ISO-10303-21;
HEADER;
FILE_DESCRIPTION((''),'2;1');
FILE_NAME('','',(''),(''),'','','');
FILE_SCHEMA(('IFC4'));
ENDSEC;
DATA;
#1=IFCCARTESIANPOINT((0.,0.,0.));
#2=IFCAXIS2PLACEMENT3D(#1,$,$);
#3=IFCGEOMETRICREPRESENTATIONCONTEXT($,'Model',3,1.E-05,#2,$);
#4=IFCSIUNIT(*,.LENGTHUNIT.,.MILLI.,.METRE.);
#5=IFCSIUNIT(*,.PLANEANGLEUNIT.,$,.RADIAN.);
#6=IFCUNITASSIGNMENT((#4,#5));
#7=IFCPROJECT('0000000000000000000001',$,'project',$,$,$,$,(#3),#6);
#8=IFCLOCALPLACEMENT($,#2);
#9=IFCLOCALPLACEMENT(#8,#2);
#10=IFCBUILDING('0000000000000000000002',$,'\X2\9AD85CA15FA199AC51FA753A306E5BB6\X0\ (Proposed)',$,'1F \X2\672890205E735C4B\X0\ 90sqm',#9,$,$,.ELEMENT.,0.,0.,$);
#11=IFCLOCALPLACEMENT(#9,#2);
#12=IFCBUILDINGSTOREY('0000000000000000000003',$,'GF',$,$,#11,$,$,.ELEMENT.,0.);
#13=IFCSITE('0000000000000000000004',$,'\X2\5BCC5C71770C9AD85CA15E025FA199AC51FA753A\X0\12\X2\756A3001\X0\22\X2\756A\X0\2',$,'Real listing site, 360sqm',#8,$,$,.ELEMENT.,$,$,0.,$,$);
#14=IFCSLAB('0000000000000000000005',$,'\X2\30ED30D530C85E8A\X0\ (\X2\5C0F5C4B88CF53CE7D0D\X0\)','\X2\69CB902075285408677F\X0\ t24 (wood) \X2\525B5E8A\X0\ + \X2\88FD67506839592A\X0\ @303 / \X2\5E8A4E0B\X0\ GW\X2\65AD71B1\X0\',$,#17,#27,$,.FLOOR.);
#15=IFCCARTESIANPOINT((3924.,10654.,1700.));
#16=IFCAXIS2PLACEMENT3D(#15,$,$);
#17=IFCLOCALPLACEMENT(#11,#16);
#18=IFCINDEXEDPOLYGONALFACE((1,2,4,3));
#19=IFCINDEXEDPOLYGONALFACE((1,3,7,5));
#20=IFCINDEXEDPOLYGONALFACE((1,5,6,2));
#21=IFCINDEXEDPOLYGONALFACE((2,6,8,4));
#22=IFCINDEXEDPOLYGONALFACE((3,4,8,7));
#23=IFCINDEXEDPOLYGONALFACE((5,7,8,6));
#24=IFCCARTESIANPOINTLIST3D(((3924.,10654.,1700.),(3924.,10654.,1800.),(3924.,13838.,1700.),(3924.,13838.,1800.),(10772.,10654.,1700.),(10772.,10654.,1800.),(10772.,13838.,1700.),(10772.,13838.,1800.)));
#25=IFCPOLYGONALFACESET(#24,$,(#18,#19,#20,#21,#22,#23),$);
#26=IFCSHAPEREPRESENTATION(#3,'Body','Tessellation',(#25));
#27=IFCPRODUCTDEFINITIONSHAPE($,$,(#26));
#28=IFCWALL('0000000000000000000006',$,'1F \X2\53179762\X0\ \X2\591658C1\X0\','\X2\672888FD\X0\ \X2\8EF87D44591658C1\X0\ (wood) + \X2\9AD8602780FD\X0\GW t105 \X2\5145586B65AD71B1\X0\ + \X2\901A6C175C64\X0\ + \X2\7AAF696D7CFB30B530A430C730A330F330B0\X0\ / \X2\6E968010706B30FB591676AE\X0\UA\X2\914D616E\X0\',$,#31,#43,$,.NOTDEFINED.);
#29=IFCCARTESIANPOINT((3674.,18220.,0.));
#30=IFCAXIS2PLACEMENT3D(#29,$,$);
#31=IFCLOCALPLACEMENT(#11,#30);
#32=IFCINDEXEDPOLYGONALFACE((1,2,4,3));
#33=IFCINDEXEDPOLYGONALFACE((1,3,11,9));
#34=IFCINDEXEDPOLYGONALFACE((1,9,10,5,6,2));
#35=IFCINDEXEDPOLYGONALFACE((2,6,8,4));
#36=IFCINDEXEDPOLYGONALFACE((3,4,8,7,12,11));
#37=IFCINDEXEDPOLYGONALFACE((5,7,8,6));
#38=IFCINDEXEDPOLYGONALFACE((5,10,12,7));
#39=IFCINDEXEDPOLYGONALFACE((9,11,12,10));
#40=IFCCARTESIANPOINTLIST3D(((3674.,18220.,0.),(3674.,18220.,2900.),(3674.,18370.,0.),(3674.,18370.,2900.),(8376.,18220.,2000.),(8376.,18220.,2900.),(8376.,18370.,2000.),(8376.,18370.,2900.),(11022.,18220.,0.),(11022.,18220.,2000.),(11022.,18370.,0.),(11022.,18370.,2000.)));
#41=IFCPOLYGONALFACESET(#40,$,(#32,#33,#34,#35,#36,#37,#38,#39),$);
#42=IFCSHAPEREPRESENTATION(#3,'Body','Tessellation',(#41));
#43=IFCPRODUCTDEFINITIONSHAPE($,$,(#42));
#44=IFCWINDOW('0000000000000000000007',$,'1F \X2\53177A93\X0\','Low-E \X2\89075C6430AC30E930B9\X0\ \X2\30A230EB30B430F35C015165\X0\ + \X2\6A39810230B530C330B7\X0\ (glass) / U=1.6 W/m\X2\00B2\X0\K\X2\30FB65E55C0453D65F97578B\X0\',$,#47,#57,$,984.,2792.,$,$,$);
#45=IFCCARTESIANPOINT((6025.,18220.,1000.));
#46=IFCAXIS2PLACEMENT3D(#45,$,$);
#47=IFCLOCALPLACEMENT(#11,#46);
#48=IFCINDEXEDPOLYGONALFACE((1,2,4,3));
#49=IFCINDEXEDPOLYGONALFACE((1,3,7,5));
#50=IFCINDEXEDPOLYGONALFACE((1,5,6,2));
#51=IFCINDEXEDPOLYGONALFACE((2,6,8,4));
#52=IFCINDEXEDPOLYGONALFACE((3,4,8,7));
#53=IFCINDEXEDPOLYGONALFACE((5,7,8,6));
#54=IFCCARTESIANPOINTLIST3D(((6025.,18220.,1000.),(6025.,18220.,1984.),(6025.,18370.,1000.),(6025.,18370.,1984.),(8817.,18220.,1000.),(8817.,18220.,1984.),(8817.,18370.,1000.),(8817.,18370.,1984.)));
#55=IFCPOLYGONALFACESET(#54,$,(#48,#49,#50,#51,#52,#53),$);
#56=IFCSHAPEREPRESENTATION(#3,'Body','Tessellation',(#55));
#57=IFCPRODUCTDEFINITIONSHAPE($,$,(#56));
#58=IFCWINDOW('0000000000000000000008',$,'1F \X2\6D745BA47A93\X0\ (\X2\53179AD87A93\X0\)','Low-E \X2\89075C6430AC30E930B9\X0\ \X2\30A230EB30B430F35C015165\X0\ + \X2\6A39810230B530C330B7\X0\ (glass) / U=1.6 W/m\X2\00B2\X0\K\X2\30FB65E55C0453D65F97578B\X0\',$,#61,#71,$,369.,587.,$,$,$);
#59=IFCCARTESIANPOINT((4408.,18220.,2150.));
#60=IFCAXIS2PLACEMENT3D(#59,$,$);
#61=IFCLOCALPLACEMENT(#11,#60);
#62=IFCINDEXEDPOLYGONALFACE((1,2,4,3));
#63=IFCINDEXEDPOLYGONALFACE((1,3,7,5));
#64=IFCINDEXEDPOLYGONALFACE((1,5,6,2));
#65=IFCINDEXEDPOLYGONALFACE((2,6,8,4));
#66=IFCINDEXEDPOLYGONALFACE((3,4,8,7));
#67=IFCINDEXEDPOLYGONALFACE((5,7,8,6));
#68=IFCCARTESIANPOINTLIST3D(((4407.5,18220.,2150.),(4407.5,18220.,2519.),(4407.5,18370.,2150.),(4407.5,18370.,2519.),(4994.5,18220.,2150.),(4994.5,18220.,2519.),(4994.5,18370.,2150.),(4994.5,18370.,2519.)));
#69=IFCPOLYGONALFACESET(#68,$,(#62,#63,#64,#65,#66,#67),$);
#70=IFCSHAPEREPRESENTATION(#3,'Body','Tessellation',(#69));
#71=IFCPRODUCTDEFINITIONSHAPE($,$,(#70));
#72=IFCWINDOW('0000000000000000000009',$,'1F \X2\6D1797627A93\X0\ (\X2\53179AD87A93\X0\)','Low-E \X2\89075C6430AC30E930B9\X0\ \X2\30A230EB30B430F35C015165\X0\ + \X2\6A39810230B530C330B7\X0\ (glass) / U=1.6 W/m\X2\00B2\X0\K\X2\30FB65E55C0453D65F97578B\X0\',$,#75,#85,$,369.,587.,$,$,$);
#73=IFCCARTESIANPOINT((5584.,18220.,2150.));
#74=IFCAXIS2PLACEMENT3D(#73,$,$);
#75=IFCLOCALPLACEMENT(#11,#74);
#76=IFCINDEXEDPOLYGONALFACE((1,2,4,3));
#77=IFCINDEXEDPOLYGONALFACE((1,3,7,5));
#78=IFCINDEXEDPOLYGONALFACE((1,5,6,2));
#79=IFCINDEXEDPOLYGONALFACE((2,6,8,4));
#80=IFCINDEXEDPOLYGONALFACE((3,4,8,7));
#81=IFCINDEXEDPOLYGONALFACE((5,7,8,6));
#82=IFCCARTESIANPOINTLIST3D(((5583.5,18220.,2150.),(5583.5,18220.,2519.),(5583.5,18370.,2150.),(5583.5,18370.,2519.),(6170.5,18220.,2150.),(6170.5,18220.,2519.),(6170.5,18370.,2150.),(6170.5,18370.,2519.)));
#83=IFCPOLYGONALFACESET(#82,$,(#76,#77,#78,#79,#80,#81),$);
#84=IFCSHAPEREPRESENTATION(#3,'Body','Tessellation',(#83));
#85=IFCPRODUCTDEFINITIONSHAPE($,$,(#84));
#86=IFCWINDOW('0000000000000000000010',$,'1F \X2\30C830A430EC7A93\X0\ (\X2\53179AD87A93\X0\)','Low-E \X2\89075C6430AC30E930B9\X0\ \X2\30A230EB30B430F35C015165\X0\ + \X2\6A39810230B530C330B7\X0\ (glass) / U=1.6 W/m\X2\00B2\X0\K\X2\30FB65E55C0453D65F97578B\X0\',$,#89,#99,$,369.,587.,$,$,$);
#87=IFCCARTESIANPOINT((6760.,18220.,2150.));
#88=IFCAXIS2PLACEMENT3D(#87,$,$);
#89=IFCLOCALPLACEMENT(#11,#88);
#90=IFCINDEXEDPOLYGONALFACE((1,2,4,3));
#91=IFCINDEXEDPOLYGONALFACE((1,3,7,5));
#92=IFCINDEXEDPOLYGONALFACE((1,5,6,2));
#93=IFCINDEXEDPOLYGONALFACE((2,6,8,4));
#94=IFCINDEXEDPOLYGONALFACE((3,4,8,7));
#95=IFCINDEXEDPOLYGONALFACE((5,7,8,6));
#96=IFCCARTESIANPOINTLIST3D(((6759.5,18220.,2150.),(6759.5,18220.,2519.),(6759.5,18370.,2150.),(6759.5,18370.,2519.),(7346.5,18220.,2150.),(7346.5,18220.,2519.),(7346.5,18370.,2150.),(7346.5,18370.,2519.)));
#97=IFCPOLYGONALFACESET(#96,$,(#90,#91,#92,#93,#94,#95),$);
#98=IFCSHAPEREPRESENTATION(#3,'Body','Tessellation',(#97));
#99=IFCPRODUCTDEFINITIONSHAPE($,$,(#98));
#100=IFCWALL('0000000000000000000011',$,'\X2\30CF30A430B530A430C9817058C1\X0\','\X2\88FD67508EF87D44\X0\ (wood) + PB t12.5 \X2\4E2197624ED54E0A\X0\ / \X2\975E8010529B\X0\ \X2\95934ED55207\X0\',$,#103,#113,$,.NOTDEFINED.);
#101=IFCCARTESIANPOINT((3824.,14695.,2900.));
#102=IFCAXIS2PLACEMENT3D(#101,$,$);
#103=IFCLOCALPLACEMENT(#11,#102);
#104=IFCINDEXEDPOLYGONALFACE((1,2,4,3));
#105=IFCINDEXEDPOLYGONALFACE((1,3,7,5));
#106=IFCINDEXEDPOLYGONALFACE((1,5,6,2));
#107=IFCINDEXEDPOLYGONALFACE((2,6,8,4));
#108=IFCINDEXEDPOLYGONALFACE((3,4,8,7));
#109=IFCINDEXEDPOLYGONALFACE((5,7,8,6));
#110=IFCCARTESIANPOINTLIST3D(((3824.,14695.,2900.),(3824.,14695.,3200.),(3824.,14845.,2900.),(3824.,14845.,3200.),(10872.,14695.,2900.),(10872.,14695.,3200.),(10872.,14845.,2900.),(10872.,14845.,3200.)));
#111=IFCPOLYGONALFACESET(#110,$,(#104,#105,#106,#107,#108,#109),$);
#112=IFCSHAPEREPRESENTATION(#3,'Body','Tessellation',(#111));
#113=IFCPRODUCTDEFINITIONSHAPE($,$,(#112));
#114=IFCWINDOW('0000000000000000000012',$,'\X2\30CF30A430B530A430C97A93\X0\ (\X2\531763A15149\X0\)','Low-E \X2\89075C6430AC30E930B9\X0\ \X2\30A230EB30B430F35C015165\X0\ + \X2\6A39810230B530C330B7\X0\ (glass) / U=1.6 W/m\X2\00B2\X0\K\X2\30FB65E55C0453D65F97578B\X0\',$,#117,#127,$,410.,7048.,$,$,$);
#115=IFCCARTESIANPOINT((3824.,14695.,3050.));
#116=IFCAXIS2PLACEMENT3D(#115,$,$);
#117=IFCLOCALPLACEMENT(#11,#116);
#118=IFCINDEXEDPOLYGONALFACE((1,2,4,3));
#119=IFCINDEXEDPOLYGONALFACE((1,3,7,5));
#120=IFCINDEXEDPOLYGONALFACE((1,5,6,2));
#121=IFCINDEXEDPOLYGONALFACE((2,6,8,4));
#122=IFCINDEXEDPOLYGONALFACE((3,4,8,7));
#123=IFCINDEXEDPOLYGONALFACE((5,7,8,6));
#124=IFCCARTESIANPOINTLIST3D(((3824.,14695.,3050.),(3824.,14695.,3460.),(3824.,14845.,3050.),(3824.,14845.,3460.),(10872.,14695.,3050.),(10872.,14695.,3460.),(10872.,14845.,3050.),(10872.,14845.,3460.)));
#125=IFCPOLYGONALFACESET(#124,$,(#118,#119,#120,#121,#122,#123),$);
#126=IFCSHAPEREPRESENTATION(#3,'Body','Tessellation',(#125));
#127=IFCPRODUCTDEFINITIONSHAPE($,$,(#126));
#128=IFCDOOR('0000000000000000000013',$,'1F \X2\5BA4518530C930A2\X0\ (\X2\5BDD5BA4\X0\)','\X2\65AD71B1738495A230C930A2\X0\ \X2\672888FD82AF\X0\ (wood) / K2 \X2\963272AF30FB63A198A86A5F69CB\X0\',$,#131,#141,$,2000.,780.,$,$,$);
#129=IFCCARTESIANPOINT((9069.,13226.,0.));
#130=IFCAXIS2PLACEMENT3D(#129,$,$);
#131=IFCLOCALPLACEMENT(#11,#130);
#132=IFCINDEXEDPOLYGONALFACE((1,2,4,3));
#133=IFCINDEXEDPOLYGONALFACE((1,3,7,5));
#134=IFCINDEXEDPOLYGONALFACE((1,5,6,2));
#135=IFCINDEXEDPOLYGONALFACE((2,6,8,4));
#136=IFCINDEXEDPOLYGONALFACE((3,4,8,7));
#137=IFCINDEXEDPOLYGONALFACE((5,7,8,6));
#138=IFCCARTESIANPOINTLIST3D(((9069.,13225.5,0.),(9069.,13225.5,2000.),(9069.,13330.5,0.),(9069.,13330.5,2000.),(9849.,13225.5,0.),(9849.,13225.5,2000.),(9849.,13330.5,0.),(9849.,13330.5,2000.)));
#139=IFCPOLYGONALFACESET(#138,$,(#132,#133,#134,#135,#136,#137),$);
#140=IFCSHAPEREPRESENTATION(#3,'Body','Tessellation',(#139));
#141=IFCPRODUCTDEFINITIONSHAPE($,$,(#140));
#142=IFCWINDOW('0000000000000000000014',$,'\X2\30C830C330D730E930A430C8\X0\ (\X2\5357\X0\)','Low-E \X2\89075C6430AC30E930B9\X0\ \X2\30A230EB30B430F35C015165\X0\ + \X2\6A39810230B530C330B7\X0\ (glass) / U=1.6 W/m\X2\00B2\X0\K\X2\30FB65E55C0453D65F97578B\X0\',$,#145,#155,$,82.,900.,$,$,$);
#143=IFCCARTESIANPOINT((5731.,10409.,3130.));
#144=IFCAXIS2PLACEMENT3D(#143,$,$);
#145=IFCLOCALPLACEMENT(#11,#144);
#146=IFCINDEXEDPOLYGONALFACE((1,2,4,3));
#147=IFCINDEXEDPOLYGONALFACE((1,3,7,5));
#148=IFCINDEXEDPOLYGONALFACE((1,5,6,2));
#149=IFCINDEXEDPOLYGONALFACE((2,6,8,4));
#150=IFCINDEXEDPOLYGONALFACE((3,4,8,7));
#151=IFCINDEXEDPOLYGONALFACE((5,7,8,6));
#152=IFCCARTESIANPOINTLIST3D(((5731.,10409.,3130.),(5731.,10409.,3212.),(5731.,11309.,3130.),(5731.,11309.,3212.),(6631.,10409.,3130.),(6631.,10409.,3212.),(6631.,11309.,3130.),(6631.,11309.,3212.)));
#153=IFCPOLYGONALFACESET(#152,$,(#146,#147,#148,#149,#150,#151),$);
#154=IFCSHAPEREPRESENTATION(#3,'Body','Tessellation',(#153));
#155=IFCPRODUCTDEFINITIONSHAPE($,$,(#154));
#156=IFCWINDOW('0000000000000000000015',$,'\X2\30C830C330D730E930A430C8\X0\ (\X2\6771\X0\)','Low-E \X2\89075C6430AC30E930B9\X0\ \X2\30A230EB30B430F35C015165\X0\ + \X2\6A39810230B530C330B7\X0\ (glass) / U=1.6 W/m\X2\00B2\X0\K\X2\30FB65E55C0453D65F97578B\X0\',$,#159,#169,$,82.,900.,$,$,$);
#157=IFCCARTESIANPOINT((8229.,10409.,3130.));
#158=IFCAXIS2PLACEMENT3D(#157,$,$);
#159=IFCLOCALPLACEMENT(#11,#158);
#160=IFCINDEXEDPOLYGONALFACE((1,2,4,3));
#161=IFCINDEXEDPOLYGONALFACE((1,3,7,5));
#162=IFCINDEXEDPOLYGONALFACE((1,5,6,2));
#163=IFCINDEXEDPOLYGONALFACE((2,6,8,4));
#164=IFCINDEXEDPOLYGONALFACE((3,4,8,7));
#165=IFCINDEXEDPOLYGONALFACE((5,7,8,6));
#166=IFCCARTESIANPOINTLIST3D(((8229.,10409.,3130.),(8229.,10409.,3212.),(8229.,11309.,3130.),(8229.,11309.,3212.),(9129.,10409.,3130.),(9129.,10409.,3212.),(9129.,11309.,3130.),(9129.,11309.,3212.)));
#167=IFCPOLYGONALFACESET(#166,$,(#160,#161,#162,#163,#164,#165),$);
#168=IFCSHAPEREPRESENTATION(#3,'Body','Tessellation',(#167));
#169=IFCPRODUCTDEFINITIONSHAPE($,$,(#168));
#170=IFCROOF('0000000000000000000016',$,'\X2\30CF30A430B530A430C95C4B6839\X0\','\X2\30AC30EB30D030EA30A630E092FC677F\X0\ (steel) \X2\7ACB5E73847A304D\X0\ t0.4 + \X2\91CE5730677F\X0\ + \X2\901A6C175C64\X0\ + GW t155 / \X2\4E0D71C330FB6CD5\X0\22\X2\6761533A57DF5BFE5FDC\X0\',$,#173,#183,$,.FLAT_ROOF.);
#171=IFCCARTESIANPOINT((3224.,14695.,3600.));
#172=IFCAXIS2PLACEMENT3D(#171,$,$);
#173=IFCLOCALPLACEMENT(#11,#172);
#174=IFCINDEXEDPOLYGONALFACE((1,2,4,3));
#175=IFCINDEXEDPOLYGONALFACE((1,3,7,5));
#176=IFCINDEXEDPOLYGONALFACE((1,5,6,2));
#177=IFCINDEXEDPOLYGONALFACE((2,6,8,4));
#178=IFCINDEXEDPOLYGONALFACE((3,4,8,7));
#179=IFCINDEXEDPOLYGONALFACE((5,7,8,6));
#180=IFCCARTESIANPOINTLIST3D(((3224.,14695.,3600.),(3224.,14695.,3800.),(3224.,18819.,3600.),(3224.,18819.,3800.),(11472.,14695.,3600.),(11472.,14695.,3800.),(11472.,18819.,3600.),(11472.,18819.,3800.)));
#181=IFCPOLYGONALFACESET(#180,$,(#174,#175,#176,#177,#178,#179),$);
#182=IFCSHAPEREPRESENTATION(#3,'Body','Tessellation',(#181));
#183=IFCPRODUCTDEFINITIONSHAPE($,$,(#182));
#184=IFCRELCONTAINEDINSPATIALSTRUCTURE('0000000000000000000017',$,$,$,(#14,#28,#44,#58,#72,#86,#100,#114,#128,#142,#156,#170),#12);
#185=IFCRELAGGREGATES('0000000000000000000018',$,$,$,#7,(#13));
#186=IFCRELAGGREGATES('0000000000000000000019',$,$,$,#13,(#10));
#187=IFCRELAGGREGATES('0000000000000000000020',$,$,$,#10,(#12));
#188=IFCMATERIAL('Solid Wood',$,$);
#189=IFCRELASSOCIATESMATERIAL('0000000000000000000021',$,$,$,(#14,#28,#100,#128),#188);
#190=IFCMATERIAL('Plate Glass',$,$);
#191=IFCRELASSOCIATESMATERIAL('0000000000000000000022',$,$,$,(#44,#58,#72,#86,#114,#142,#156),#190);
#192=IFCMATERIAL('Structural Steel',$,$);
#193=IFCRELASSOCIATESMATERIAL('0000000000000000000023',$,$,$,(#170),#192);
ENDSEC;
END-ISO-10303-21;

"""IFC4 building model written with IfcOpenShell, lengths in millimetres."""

from ifc_helpers import new_model, si_unit, frame, frame_2d, origin, place, context, project, spatial, rectangle, extrude, material, element, fill, save


model = new_model("IFC4")

# Units and contexts
model_context = context("Model", 3, precision=1e-05, world=origin())
ifc_project = project(units=[si_unit("LENGTHUNIT", "METRE", prefix="MILLI"), si_unit("PLANEANGLEUNIT", "RADIAN")], contexts=[model_context])

# Site, building, storey
site_placement = place(None, origin())
site = spatial("IfcSite", under=ifc_project, at=site_placement, Name="富山県高岡市御馬出町12番、22番2", ObjectType="Real listing site, 360sqm", CompositionType="ELEMENT", RefElevation=0.0)
building_placement = place(site_placement, origin())
building = spatial("IfcBuilding", under=site, at=building_placement, Name="高岡御馬出町の家 (Proposed)", ObjectType="1F 木造平屋 90sqm", CompositionType="ELEMENT", ElevationOfRefHeight=0.0, ElevationOfTerrain=0.0)
storey_placement = place(building_placement, origin())
storey = spatial("IfcBuildingStorey", under=building, at=storey_placement, Name="GF", CompositionType="ELEMENT", Elevation=0.0)

# Slab
ifc_material_1 = material(Name="Solid Wood")
slab_placement = place(storey_placement, frame((3924.0, 10654.0, 1700.0)))
element("IfcSlab", 1, at=slab_placement, inside=storey, material=ifc_material_1, Name="ロフト床 (小屋裏収納)", Description="構造用合板 t24 (wood) 剛床 + 製材根太 @303 / 床下 GW断熱", PredefinedType="FLOOR", context=model_context, shape_type="SweptSolid", body=[
    extrude(rectangle(XDim=6848.0, YDim=3184.0, at=frame_2d((3424.0, 1592.0))), frame((3924.0, 10654.0, 1700.0)), (0.0, 0.0, 1.0), 100.0),
])

# Wall, openings, windows
wall_1_placement = place(storey_placement, frame((3674.0, 18220.0, 0.0)))
wall_1 = element("IfcWall", 2, at=wall_1_placement, inside=storey, material=ifc_material_1, Name="1F 北面 外壁", Description="木製 軸組外壁 (wood) + 高性能GW t105 充填断熱 + 通気層 + 窯業系サイディング / 準耐火・外皮UA配慮", PredefinedType="NOTDEFINED", context=model_context, shape_type="SweptSolid", body=[
    extrude(rectangle(XDim=7348.0, YDim=150.0, at=frame_2d((3674.0, 75.0))), frame((3674.0, 18220.0, 0.0)), (0.0, 0.0, 1.0), 2900.0),
])
opening_1_placement = place(storey_placement, frame((6025.0, 18220.0, 1000.0)))
opening_1 = element("IfcOpeningElement", 3, at=opening_1_placement, cuts=wall_1, PredefinedType="NOTDEFINED", context=model_context, shape_type="SweptSolid", body=[
    extrude(rectangle(XDim=2792.0, YDim=150.0, at=frame_2d((1396.0, 75.0))), frame((6025.0, 18220.0, 1000.0)), (0.0, 0.0, 1.0), 984.0),
])
opening_2_placement = place(storey_placement, frame((4408.0, 18220.0, 2150.0)))
opening_2 = element("IfcOpeningElement", 4, at=opening_2_placement, cuts=wall_1, PredefinedType="NOTDEFINED", context=model_context, shape_type="SweptSolid", body=[
    extrude(rectangle(XDim=587.0, YDim=150.0, at=frame_2d((293.0, 75.0))), frame((4408.0, 18220.0, 2150.0)), (0.0, 0.0, 1.0), 369.0),
])
opening_3_placement = place(storey_placement, frame((5584.0, 18220.0, 2150.0)))
opening_3 = element("IfcOpeningElement", 5, at=opening_3_placement, cuts=wall_1, PredefinedType="NOTDEFINED", context=model_context, shape_type="SweptSolid", body=[
    extrude(rectangle(XDim=587.0, YDim=150.0, at=frame_2d((293.0, 75.0))), frame((5584.0, 18220.0, 2150.0)), (0.0, 0.0, 1.0), 369.0),
])
opening_4_placement = place(storey_placement, frame((6760.0, 18220.0, 2150.0)))
opening_4 = element("IfcOpeningElement", 6, at=opening_4_placement, cuts=wall_1, PredefinedType="NOTDEFINED", context=model_context, shape_type="SweptSolid", body=[
    extrude(rectangle(XDim=587.0, YDim=150.0, at=frame_2d((293.0, 75.0))), frame((6760.0, 18220.0, 2150.0)), (0.0, 0.0, 1.0), 369.0),
])
ifc_material_2 = material(Name="Plate Glass")
window_1_placement = place(storey_placement, frame((6025.0, 18220.0, 1000.0)))
window_1 = element("IfcWindow", 7, at=window_1_placement, inside=storey, material=ifc_material_2, Name="1F 北窓", Description="Low-E 複層ガラス アルゴン封入 + 樹脂サッシ (glass) / U=1.6 W/m²K・日射取得型", OverallHeight=984.0, OverallWidth=2792.0, context=model_context, shape_type="SweptSolid", body=[
    extrude(rectangle(XDim=2792.0, YDim=150.0, at=frame_2d((1396.0, 75.0))), frame((6025.0, 18220.0, 1000.0)), (0.0, 0.0, 1.0), 984.0),
])
fill(opening_1, window_1)
window_2_placement = place(storey_placement, frame((4408.0, 18220.0, 2150.0)))
window_2 = element("IfcWindow", 8, at=window_2_placement, inside=storey, material=ifc_material_2, Name="1F 浴室窓 (北高窓)", Description="Low-E 複層ガラス アルゴン封入 + 樹脂サッシ (glass) / U=1.6 W/m²K・日射取得型", OverallHeight=369.0, OverallWidth=587.0, context=model_context, shape_type="SweptSolid", body=[
    extrude(rectangle(XDim=587.0, YDim=150.0, at=frame_2d((293.0, 75.0))), frame((4408.0, 18220.0, 2150.0)), (0.0, 0.0, 1.0), 369.0),
])
fill(opening_2, window_2)
window_3_placement = place(storey_placement, frame((5584.0, 18220.0, 2150.0)))
window_3 = element("IfcWindow", 9, at=window_3_placement, inside=storey, material=ifc_material_2, Name="1F 洗面窓 (北高窓)", Description="Low-E 複層ガラス アルゴン封入 + 樹脂サッシ (glass) / U=1.6 W/m²K・日射取得型", OverallHeight=369.0, OverallWidth=587.0, context=model_context, shape_type="SweptSolid", body=[
    extrude(rectangle(XDim=587.0, YDim=150.0, at=frame_2d((293.0, 75.0))), frame((5584.0, 18220.0, 2150.0)), (0.0, 0.0, 1.0), 369.0),
])
fill(opening_3, window_3)
window_4_placement = place(storey_placement, frame((6760.0, 18220.0, 2150.0)))
window_4 = element("IfcWindow", 10, at=window_4_placement, inside=storey, material=ifc_material_2, Name="1F トイレ窓 (北高窓)", Description="Low-E 複層ガラス アルゴン封入 + 樹脂サッシ (glass) / U=1.6 W/m²K・日射取得型", OverallHeight=369.0, OverallWidth=587.0, context=model_context, shape_type="SweptSolid", body=[
    extrude(rectangle(XDim=587.0, YDim=150.0, at=frame_2d((293.0, 75.0))), frame((6760.0, 18220.0, 2150.0)), (0.0, 0.0, 1.0), 369.0),
])
fill(opening_4, window_4)

# Wall, opening, window
wall_2_placement = place(storey_placement, frame((3824.0, 14695.0, 2900.0)))
wall_2 = element("IfcWall", 11, at=wall_2_placement, inside=storey, material=ifc_material_1, Name="ハイサイド腰壁", Description="製材軸組 (wood) + PB t12.5 両面仕上 / 非耐力 間仕切", PredefinedType="NOTDEFINED", context=model_context, shape_type="SweptSolid", body=[
    extrude(rectangle(XDim=7048.0, YDim=150.0, at=frame_2d((3524.0, 75.0))), frame((3824.0, 14695.0, 2900.0)), (0.0, 0.0, 1.0), 700.0),
])
opening_5_placement = place(storey_placement, frame((3824.0, 14695.0, 3050.0)))
opening_5 = element("IfcOpeningElement", 12, at=opening_5_placement, cuts=wall_2, PredefinedType="NOTDEFINED", context=model_context, shape_type="SweptSolid", body=[
    extrude(rectangle(XDim=7048.0, YDim=150.0, at=frame_2d((3524.0, 75.0))), frame((3824.0, 14695.0, 3050.0)), (0.0, 0.0, 1.0), 410.0),
])
window_5_placement = place(storey_placement, frame((3824.0, 14695.0, 3050.0)))
window_5 = element("IfcWindow", 13, at=window_5_placement, inside=storey, material=ifc_material_2, Name="ハイサイド窓 (北採光)", Description="Low-E 複層ガラス アルゴン封入 + 樹脂サッシ (glass) / U=1.6 W/m²K・日射取得型", OverallHeight=410.0, OverallWidth=7048.0, context=model_context, shape_type="SweptSolid", body=[
    extrude(rectangle(XDim=7048.0, YDim=150.0, at=frame_2d((3524.0, 75.0))), frame((3824.0, 14695.0, 3050.0)), (0.0, 0.0, 1.0), 410.0),
])
fill(opening_5, window_5)

# Door
door_1_placement = place(storey_placement, frame((9069.0, 13226.0, 0.0)))
element("IfcDoor", 14, at=door_1_placement, inside=storey, material=ifc_material_1, Name="1F 室内ドア (寝室)", Description="断熱玄関ドア 木製芯 (wood) / K2 防犯・採風機構", OverallHeight=2000.0, OverallWidth=780.0, context=model_context, shape_type="SweptSolid", body=[
    extrude(rectangle(XDim=780.0, YDim=105.0, at=frame_2d((390.0, 52.0))), frame((9069.0, 13226.0, 0.0)), (0.0, 0.0, 1.0), 2000.0),
])

# Windows
window_6_placement = place(storey_placement, frame((5731.0, 10409.0, 3130.0)))
element("IfcWindow", 15, at=window_6_placement, inside=storey, material=ifc_material_2, Name="トップライト (南)", Description="Low-E 複層ガラス アルゴン封入 + 樹脂サッシ (glass) / U=1.6 W/m²K・日射取得型", OverallHeight=82.0, OverallWidth=900.0, context=model_context, shape_type="SweptSolid", body=[
    extrude(rectangle(XDim=900.0, YDim=900.0, at=frame_2d((450.0, 450.0))), frame((5731.0, 10409.0, 3130.0)), (0.0, 0.0, 1.0), 82.0),
])
window_7_placement = place(storey_placement, frame((8229.0, 10409.0, 3130.0)))
element("IfcWindow", 16, at=window_7_placement, inside=storey, material=ifc_material_2, Name="トップライト (東)", Description="Low-E 複層ガラス アルゴン封入 + 樹脂サッシ (glass) / U=1.6 W/m²K・日射取得型", OverallHeight=82.0, OverallWidth=900.0, context=model_context, shape_type="SweptSolid", body=[
    extrude(rectangle(XDim=900.0, YDim=900.0, at=frame_2d((450.0, 450.0))), frame((8229.0, 10409.0, 3130.0)), (0.0, 0.0, 1.0), 82.0),
])

# Roof
ifc_material_3 = material(Name="Structural Steel")
roof_placement = place(storey_placement, frame((3224.0, 14695.0, 3600.0)))
element("IfcRoof", 17, at=roof_placement, inside=storey, material=ifc_material_3, Name="ハイサイド屋根", Description="ガルバリウム鋼板 (steel) 立平葺き t0.4 + 野地板 + 通気層 + GW t155 / 不燃・法22条区域対応", PredefinedType="FLAT_ROOF", context=model_context, shape_type="SweptSolid", body=[
    extrude(rectangle(XDim=8248.0, YDim=4124.0, at=frame_2d((4124.0, 2062.0))), frame((3224.0, 14695.0, 3600.0)), (0.0, 0.0, 1.0), 200.0),
])

save(model, "model.ifc")
